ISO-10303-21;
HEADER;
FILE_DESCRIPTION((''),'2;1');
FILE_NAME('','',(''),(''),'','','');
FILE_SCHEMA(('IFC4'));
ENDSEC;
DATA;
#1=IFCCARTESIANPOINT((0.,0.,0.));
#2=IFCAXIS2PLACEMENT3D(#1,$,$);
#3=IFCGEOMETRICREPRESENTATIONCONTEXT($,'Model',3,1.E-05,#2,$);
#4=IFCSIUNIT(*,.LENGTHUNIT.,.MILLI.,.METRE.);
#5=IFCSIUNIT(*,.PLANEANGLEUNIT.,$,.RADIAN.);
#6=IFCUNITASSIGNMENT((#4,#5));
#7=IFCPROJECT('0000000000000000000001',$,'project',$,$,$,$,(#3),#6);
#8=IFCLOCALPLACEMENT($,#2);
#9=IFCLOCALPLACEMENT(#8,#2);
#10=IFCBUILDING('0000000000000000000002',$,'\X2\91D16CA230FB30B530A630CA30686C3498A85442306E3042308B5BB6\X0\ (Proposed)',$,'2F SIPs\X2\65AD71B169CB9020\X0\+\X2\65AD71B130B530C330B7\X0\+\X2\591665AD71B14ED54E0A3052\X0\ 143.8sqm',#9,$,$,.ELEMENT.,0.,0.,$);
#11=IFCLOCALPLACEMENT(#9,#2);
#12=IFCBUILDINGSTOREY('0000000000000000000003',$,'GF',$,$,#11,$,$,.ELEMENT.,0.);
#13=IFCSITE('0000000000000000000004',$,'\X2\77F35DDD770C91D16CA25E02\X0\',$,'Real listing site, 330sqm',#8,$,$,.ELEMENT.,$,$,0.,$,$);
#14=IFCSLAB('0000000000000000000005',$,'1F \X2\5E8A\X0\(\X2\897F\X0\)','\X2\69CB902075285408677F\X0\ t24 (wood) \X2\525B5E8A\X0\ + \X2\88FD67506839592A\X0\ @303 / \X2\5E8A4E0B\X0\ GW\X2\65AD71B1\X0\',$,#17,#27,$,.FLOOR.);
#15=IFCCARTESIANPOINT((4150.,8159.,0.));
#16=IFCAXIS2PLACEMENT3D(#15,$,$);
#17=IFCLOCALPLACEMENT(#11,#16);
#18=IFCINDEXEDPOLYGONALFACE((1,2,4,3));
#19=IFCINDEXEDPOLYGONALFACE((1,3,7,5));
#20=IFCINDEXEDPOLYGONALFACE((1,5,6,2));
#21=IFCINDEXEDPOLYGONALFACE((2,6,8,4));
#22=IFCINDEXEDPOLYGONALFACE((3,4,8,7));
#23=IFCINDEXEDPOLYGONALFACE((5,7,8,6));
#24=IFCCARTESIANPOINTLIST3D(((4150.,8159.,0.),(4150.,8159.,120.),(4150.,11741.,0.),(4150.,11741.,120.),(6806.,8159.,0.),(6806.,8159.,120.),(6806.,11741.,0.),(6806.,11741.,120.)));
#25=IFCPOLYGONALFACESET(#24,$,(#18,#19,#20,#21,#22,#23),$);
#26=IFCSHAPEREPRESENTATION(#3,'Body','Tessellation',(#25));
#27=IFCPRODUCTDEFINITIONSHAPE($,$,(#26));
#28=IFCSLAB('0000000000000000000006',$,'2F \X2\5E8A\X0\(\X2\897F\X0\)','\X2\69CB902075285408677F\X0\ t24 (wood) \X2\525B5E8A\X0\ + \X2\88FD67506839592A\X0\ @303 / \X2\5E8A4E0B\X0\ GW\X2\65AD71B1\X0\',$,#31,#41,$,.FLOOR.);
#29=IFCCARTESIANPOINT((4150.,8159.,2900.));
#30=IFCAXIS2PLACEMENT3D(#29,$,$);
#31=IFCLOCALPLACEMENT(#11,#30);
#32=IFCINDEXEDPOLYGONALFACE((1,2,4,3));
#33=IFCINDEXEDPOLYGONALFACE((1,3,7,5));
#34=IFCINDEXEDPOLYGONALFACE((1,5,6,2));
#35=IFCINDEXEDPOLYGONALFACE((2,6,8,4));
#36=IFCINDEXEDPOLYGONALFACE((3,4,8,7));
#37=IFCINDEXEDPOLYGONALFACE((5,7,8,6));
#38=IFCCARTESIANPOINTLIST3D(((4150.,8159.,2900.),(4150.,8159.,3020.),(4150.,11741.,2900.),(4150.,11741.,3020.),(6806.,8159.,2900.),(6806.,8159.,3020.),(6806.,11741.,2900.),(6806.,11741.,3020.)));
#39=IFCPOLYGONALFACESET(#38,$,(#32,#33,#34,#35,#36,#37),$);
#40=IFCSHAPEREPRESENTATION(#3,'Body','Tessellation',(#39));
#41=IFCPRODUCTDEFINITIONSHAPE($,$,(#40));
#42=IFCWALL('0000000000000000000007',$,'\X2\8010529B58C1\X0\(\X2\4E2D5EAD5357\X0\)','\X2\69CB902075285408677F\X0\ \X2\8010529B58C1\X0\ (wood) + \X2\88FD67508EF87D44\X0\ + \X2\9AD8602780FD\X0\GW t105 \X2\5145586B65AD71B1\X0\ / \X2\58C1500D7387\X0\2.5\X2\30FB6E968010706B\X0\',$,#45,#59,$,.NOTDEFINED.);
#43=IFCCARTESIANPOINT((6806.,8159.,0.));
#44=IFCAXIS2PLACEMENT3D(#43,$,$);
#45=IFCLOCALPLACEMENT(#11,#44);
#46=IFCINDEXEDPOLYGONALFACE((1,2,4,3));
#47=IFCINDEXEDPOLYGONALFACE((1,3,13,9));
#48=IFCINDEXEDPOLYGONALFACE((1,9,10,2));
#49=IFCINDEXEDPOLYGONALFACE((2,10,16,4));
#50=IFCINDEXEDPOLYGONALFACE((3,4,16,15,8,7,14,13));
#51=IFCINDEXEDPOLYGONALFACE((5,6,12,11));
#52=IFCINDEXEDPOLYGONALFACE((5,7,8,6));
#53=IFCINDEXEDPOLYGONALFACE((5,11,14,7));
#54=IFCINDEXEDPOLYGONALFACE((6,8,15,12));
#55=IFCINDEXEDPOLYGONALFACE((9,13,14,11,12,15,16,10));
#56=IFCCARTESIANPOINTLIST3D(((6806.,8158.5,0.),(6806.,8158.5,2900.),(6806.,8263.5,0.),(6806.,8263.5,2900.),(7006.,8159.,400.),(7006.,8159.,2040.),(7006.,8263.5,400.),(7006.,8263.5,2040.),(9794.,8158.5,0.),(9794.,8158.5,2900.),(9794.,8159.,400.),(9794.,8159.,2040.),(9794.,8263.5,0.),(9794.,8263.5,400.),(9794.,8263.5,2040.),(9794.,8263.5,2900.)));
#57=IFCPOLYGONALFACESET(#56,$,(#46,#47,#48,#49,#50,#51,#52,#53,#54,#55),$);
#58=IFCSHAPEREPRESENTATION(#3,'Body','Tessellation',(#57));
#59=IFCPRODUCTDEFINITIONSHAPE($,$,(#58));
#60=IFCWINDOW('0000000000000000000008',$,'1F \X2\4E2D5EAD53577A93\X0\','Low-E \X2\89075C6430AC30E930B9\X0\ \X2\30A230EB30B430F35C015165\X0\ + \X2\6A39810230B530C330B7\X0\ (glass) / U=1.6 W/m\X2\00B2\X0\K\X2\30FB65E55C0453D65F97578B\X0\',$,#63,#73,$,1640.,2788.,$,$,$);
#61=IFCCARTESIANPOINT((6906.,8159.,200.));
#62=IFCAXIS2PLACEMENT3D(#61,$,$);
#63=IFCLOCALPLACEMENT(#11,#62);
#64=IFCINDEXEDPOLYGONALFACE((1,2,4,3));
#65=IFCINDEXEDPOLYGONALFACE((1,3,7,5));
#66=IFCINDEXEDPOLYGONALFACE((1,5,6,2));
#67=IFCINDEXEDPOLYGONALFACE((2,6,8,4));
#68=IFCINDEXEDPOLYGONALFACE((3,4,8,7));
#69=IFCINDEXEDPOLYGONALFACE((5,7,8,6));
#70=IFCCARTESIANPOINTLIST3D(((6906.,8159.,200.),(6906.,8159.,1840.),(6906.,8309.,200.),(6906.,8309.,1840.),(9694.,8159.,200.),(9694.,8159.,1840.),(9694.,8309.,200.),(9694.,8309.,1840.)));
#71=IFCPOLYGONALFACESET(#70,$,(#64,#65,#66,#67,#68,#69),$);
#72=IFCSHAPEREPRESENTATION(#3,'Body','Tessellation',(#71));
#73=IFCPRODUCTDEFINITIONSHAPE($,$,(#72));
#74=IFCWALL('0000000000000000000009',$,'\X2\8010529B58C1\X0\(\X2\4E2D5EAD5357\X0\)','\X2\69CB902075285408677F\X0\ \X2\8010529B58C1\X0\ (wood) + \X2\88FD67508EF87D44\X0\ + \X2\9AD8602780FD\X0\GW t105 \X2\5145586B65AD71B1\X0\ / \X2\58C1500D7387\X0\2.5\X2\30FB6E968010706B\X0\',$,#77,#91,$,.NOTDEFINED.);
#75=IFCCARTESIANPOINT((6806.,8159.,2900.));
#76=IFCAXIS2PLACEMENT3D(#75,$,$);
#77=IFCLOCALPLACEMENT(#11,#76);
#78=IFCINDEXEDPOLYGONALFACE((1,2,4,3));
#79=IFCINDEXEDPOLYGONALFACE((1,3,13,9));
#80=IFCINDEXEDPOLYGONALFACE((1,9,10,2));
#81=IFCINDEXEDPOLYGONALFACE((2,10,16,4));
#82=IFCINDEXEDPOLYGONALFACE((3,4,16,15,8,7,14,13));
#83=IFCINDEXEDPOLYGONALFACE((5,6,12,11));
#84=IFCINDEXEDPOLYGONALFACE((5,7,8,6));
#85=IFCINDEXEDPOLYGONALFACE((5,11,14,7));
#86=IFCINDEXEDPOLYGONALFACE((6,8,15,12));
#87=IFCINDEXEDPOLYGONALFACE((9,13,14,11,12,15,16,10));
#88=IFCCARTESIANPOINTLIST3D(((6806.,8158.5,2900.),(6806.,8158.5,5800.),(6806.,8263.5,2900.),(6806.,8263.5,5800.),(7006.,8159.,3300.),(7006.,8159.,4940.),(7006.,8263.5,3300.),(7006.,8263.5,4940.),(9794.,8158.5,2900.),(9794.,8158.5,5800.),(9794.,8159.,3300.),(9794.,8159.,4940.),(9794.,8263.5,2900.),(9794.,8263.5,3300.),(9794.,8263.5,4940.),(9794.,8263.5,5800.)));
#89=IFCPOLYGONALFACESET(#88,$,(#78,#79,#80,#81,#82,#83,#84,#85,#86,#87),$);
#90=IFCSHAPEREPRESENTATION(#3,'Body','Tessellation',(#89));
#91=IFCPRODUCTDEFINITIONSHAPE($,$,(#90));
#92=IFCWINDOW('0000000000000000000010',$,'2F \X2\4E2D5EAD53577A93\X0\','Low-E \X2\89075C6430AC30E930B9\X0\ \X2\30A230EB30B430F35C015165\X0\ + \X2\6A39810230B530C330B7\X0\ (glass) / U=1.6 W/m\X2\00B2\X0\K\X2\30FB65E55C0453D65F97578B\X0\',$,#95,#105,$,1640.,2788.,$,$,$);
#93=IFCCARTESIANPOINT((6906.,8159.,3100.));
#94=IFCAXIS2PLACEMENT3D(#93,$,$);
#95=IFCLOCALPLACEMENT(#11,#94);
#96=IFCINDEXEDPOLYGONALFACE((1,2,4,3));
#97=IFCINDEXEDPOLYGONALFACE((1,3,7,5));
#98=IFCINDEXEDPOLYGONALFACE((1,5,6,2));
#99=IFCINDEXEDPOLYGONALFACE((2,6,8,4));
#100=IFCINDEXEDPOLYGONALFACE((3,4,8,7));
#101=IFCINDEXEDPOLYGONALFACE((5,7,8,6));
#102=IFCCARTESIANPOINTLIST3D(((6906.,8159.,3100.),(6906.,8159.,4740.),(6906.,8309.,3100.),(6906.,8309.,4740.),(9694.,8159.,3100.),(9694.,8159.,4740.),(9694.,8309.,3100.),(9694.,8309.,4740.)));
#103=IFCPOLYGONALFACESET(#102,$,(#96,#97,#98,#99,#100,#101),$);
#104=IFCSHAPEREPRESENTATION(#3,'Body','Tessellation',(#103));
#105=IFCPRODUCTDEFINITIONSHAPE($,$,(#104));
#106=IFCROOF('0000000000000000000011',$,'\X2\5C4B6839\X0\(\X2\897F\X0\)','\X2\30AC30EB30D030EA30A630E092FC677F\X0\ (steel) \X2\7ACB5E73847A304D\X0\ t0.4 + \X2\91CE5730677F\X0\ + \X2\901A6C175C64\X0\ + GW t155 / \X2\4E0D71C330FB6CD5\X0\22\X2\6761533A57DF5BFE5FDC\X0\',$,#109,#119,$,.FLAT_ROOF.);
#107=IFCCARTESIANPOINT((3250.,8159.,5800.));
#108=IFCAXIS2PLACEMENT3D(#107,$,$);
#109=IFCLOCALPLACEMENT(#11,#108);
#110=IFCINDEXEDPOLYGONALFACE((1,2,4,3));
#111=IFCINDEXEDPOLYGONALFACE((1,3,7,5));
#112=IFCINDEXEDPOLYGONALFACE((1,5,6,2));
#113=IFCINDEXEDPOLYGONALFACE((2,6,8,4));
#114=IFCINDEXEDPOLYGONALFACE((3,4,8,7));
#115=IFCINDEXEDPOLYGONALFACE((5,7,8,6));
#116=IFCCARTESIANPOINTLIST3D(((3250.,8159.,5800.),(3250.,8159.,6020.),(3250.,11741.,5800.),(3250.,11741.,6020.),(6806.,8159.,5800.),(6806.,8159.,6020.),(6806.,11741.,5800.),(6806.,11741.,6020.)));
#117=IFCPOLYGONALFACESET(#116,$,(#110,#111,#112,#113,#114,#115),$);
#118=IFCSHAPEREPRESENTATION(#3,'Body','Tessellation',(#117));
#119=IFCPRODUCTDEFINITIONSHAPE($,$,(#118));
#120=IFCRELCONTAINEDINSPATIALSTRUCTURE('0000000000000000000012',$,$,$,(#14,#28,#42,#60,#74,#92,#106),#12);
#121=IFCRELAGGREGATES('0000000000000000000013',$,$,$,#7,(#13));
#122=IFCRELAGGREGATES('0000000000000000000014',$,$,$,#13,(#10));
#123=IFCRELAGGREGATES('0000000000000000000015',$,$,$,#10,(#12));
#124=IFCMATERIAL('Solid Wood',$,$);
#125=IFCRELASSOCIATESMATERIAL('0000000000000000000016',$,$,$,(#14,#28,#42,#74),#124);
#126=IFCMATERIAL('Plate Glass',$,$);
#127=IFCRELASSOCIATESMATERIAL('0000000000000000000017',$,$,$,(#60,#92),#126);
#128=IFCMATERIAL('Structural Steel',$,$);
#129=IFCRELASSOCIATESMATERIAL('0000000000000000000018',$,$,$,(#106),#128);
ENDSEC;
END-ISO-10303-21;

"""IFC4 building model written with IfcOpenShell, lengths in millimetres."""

from ifc_helpers import new_model, si_unit, frame, frame_2d, origin, place, context, project, spatial, rectangle, extrude, material, element, fill, save


model = new_model("IFC4")

# Units and contexts
model_context = context("Model", 3, precision=1e-05, world=origin())
ifc_project = project(units=[si_unit("LENGTHUNIT", "METRE", prefix="MILLI"), si_unit("PLANEANGLEUNIT", "RADIAN")], contexts=[model_context])

# Site, building, storey
site_placement = place(None, origin())
site = spatial("IfcSite", under=ifc_project, at=site_placement, Name="石川県金沢市", ObjectType="Real listing site, 330sqm", CompositionType="ELEMENT", RefElevation=0.0)
building_placement = place(site_placement, origin())
building = spatial("IfcBuilding", under=site, at=building_placement, Name="金沢・サウナと水風呂のある家 (Proposed)", ObjectType="2F SIPs断熱構造+断熱サッシ+外断熱仕上げ 143.8sqm", CompositionType="ELEMENT", ElevationOfRefHeight=0.0, ElevationOfTerrain=0.0)
storey_placement = place(building_placement, origin())
storey = spatial("IfcBuildingStorey", under=building, at=storey_placement, Name="GF", CompositionType="ELEMENT", Elevation=0.0)

# Shared definitions
ifc_material_1 = material(Name="Solid Wood")

# Slabs
slab_1_placement = place(storey_placement, frame((4150.0, 8159.0, 0.0)))
element("IfcSlab", 1, at=slab_1_placement, inside=storey, material=ifc_material_1, Name="1F 床(西)", Description="構造用合板 t24 (wood) 剛床 + 製材根太 @303 / 床下 GW断熱", PredefinedType="FLOOR", context=model_context, shape_type="SweptSolid", body=[
    extrude(rectangle(XDim=2656.0, YDim=3582.0, at=frame_2d((1328.0, 1791.0))), frame((4150.0, 8159.0, 0.0)), (0.0, 0.0, 1.0), 120.0),
])
slab_2_placement = place(storey_placement, frame((4150.0, 8159.0, 2900.0)))
element("IfcSlab", 2, at=slab_2_placement, inside=storey, material=ifc_material_1, Name="2F 床(西)", Description="構造用合板 t24 (wood) 剛床 + 製材根太 @303 / 床下 GW断熱", PredefinedType="FLOOR", context=model_context, shape_type="SweptSolid", body=[
    extrude(rectangle(XDim=2656.0, YDim=3582.0, at=frame_2d((1328.0, 1791.0))), frame((4150.0, 8159.0, 2900.0)), (0.0, 0.0, 1.0), 120.0),
])

# Wall, opening, window
wall_1_placement = place(storey_placement, frame((6806.0, 8159.0, 0.0)))
wall_1 = element("IfcWall", 3, at=wall_1_placement, inside=storey, material=ifc_material_1, Name="耐力壁(中庭南)", Description="構造用合板 耐力壁 (wood) + 製材軸組 + 高性能GW t105 充填断熱 / 壁倍率2.5・準耐火", PredefinedType="NOTDEFINED", context=model_context, shape_type="SweptSolid", body=[
    extrude(rectangle(XDim=2988.0, YDim=105.0, at=frame_2d((1494.0, 52.0))), frame((6806.0, 8159.0, 0.0)), (0.0, 0.0, 1.0), 2900.0),
])
opening_1_placement = place(storey_placement, frame((6906.0, 8159.0, 200.0)))
opening_1 = element("IfcOpeningElement", 4, at=opening_1_placement, cuts=wall_1, PredefinedType="NOTDEFINED", context=model_context, shape_type="SweptSolid", body=[
    extrude(rectangle(XDim=2788.0, YDim=150.0, at=frame_2d((1394.0, 75.0))), frame((6906.0, 8159.0, 200.0)), (0.0, 0.0, 1.0), 1640.0),
])
ifc_material_2 = material(Name="Plate Glass")
window_1_placement = place(storey_placement, frame((6906.0, 8159.0, 200.0)))
window_1 = element("IfcWindow", 5, at=window_1_placement, inside=storey, material=ifc_material_2, Name="1F 中庭南窓", Description="Low-E 複層ガラス アルゴン封入 + 樹脂サッシ (glass) / U=1.6 W/m²K・日射取得型", OverallHeight=1640.0, OverallWidth=2788.0, context=model_context, shape_type="SweptSolid", body=[
    extrude(rectangle(XDim=2788.0, YDim=150.0, at=frame_2d((1394.0, 75.0))), frame((6906.0, 8159.0, 200.0)), (0.0, 0.0, 1.0), 1640.0),
])
fill(opening_1, window_1)

# Wall, opening, window
wall_2_placement = place(storey_placement, frame((6806.0, 8159.0, 2900.0)))
wall_2 = element("IfcWall", 6, at=wall_2_placement, inside=storey, material=ifc_material_1, Name="耐力壁(中庭南)", Description="構造用合板 耐力壁 (wood) + 製材軸組 + 高性能GW t105 充填断熱 / 壁倍率2.5・準耐火", PredefinedType="NOTDEFINED", context=model_context, shape_type="SweptSolid", body=[
    extrude(rectangle(XDim=2988.0, YDim=105.0, at=frame_2d((1494.0, 52.0))), frame((6806.0, 8159.0, 2900.0)), (0.0, 0.0, 1.0), 2900.0),
])
opening_2_placement = place(storey_placement, frame((6906.0, 8159.0, 3100.0)))
opening_2 = element("IfcOpeningElement", 7, at=opening_2_placement, cuts=wall_2, PredefinedType="NOTDEFINED", context=model_context, shape_type="SweptSolid", body=[
    extrude(rectangle(XDim=2788.0, YDim=150.0, at=frame_2d((1394.0, 75.0))), frame((6906.0, 8159.0, 3100.0)), (0.0, 0.0, 1.0), 1640.0),
])
window_2_placement = place(storey_placement, frame((6906.0, 8159.0, 3100.0)))
window_2 = element("IfcWindow", 8, at=window_2_placement, inside=storey, material=ifc_material_2, Name="2F 中庭南窓", Description="Low-E 複層ガラス アルゴン封入 + 樹脂サッシ (glass) / U=1.6 W/m²K・日射取得型", OverallHeight=1640.0, OverallWidth=2788.0, context=model_context, shape_type="SweptSolid", body=[
    extrude(rectangle(XDim=2788.0, YDim=150.0, at=frame_2d((1394.0, 75.0))), frame((6906.0, 8159.0, 3100.0)), (0.0, 0.0, 1.0), 1640.0),
])
fill(opening_2, window_2)

# Roof
ifc_material_3 = material(Name="Structural Steel")
for number, where, name in (
    (9, (3250.0, 8159.0, 5800.0), "屋根(西)"),
):
    element("IfcRoof", number, at=place(storey_placement, frame(where)), inside=storey, material=ifc_material_3, Name=name, Description="ガルバリウム鋼板 (steel) 立平葺き t0.4 + 野地板 + 通気層 + GW t155 / 不燃・法22条区域対応", PredefinedType="FLAT_ROOF", context=model_context, shape_type="SweptSolid", body=[
        extrude(rectangle(XDim=3556.0, YDim=3582.0, at=frame_2d((1778.0, 1791.0))), frame((3250.0, 8159.0, 5800.0)), (0.0, 0.0, 1.0), 220.0),
    ])

save(model, "model.ifc")
